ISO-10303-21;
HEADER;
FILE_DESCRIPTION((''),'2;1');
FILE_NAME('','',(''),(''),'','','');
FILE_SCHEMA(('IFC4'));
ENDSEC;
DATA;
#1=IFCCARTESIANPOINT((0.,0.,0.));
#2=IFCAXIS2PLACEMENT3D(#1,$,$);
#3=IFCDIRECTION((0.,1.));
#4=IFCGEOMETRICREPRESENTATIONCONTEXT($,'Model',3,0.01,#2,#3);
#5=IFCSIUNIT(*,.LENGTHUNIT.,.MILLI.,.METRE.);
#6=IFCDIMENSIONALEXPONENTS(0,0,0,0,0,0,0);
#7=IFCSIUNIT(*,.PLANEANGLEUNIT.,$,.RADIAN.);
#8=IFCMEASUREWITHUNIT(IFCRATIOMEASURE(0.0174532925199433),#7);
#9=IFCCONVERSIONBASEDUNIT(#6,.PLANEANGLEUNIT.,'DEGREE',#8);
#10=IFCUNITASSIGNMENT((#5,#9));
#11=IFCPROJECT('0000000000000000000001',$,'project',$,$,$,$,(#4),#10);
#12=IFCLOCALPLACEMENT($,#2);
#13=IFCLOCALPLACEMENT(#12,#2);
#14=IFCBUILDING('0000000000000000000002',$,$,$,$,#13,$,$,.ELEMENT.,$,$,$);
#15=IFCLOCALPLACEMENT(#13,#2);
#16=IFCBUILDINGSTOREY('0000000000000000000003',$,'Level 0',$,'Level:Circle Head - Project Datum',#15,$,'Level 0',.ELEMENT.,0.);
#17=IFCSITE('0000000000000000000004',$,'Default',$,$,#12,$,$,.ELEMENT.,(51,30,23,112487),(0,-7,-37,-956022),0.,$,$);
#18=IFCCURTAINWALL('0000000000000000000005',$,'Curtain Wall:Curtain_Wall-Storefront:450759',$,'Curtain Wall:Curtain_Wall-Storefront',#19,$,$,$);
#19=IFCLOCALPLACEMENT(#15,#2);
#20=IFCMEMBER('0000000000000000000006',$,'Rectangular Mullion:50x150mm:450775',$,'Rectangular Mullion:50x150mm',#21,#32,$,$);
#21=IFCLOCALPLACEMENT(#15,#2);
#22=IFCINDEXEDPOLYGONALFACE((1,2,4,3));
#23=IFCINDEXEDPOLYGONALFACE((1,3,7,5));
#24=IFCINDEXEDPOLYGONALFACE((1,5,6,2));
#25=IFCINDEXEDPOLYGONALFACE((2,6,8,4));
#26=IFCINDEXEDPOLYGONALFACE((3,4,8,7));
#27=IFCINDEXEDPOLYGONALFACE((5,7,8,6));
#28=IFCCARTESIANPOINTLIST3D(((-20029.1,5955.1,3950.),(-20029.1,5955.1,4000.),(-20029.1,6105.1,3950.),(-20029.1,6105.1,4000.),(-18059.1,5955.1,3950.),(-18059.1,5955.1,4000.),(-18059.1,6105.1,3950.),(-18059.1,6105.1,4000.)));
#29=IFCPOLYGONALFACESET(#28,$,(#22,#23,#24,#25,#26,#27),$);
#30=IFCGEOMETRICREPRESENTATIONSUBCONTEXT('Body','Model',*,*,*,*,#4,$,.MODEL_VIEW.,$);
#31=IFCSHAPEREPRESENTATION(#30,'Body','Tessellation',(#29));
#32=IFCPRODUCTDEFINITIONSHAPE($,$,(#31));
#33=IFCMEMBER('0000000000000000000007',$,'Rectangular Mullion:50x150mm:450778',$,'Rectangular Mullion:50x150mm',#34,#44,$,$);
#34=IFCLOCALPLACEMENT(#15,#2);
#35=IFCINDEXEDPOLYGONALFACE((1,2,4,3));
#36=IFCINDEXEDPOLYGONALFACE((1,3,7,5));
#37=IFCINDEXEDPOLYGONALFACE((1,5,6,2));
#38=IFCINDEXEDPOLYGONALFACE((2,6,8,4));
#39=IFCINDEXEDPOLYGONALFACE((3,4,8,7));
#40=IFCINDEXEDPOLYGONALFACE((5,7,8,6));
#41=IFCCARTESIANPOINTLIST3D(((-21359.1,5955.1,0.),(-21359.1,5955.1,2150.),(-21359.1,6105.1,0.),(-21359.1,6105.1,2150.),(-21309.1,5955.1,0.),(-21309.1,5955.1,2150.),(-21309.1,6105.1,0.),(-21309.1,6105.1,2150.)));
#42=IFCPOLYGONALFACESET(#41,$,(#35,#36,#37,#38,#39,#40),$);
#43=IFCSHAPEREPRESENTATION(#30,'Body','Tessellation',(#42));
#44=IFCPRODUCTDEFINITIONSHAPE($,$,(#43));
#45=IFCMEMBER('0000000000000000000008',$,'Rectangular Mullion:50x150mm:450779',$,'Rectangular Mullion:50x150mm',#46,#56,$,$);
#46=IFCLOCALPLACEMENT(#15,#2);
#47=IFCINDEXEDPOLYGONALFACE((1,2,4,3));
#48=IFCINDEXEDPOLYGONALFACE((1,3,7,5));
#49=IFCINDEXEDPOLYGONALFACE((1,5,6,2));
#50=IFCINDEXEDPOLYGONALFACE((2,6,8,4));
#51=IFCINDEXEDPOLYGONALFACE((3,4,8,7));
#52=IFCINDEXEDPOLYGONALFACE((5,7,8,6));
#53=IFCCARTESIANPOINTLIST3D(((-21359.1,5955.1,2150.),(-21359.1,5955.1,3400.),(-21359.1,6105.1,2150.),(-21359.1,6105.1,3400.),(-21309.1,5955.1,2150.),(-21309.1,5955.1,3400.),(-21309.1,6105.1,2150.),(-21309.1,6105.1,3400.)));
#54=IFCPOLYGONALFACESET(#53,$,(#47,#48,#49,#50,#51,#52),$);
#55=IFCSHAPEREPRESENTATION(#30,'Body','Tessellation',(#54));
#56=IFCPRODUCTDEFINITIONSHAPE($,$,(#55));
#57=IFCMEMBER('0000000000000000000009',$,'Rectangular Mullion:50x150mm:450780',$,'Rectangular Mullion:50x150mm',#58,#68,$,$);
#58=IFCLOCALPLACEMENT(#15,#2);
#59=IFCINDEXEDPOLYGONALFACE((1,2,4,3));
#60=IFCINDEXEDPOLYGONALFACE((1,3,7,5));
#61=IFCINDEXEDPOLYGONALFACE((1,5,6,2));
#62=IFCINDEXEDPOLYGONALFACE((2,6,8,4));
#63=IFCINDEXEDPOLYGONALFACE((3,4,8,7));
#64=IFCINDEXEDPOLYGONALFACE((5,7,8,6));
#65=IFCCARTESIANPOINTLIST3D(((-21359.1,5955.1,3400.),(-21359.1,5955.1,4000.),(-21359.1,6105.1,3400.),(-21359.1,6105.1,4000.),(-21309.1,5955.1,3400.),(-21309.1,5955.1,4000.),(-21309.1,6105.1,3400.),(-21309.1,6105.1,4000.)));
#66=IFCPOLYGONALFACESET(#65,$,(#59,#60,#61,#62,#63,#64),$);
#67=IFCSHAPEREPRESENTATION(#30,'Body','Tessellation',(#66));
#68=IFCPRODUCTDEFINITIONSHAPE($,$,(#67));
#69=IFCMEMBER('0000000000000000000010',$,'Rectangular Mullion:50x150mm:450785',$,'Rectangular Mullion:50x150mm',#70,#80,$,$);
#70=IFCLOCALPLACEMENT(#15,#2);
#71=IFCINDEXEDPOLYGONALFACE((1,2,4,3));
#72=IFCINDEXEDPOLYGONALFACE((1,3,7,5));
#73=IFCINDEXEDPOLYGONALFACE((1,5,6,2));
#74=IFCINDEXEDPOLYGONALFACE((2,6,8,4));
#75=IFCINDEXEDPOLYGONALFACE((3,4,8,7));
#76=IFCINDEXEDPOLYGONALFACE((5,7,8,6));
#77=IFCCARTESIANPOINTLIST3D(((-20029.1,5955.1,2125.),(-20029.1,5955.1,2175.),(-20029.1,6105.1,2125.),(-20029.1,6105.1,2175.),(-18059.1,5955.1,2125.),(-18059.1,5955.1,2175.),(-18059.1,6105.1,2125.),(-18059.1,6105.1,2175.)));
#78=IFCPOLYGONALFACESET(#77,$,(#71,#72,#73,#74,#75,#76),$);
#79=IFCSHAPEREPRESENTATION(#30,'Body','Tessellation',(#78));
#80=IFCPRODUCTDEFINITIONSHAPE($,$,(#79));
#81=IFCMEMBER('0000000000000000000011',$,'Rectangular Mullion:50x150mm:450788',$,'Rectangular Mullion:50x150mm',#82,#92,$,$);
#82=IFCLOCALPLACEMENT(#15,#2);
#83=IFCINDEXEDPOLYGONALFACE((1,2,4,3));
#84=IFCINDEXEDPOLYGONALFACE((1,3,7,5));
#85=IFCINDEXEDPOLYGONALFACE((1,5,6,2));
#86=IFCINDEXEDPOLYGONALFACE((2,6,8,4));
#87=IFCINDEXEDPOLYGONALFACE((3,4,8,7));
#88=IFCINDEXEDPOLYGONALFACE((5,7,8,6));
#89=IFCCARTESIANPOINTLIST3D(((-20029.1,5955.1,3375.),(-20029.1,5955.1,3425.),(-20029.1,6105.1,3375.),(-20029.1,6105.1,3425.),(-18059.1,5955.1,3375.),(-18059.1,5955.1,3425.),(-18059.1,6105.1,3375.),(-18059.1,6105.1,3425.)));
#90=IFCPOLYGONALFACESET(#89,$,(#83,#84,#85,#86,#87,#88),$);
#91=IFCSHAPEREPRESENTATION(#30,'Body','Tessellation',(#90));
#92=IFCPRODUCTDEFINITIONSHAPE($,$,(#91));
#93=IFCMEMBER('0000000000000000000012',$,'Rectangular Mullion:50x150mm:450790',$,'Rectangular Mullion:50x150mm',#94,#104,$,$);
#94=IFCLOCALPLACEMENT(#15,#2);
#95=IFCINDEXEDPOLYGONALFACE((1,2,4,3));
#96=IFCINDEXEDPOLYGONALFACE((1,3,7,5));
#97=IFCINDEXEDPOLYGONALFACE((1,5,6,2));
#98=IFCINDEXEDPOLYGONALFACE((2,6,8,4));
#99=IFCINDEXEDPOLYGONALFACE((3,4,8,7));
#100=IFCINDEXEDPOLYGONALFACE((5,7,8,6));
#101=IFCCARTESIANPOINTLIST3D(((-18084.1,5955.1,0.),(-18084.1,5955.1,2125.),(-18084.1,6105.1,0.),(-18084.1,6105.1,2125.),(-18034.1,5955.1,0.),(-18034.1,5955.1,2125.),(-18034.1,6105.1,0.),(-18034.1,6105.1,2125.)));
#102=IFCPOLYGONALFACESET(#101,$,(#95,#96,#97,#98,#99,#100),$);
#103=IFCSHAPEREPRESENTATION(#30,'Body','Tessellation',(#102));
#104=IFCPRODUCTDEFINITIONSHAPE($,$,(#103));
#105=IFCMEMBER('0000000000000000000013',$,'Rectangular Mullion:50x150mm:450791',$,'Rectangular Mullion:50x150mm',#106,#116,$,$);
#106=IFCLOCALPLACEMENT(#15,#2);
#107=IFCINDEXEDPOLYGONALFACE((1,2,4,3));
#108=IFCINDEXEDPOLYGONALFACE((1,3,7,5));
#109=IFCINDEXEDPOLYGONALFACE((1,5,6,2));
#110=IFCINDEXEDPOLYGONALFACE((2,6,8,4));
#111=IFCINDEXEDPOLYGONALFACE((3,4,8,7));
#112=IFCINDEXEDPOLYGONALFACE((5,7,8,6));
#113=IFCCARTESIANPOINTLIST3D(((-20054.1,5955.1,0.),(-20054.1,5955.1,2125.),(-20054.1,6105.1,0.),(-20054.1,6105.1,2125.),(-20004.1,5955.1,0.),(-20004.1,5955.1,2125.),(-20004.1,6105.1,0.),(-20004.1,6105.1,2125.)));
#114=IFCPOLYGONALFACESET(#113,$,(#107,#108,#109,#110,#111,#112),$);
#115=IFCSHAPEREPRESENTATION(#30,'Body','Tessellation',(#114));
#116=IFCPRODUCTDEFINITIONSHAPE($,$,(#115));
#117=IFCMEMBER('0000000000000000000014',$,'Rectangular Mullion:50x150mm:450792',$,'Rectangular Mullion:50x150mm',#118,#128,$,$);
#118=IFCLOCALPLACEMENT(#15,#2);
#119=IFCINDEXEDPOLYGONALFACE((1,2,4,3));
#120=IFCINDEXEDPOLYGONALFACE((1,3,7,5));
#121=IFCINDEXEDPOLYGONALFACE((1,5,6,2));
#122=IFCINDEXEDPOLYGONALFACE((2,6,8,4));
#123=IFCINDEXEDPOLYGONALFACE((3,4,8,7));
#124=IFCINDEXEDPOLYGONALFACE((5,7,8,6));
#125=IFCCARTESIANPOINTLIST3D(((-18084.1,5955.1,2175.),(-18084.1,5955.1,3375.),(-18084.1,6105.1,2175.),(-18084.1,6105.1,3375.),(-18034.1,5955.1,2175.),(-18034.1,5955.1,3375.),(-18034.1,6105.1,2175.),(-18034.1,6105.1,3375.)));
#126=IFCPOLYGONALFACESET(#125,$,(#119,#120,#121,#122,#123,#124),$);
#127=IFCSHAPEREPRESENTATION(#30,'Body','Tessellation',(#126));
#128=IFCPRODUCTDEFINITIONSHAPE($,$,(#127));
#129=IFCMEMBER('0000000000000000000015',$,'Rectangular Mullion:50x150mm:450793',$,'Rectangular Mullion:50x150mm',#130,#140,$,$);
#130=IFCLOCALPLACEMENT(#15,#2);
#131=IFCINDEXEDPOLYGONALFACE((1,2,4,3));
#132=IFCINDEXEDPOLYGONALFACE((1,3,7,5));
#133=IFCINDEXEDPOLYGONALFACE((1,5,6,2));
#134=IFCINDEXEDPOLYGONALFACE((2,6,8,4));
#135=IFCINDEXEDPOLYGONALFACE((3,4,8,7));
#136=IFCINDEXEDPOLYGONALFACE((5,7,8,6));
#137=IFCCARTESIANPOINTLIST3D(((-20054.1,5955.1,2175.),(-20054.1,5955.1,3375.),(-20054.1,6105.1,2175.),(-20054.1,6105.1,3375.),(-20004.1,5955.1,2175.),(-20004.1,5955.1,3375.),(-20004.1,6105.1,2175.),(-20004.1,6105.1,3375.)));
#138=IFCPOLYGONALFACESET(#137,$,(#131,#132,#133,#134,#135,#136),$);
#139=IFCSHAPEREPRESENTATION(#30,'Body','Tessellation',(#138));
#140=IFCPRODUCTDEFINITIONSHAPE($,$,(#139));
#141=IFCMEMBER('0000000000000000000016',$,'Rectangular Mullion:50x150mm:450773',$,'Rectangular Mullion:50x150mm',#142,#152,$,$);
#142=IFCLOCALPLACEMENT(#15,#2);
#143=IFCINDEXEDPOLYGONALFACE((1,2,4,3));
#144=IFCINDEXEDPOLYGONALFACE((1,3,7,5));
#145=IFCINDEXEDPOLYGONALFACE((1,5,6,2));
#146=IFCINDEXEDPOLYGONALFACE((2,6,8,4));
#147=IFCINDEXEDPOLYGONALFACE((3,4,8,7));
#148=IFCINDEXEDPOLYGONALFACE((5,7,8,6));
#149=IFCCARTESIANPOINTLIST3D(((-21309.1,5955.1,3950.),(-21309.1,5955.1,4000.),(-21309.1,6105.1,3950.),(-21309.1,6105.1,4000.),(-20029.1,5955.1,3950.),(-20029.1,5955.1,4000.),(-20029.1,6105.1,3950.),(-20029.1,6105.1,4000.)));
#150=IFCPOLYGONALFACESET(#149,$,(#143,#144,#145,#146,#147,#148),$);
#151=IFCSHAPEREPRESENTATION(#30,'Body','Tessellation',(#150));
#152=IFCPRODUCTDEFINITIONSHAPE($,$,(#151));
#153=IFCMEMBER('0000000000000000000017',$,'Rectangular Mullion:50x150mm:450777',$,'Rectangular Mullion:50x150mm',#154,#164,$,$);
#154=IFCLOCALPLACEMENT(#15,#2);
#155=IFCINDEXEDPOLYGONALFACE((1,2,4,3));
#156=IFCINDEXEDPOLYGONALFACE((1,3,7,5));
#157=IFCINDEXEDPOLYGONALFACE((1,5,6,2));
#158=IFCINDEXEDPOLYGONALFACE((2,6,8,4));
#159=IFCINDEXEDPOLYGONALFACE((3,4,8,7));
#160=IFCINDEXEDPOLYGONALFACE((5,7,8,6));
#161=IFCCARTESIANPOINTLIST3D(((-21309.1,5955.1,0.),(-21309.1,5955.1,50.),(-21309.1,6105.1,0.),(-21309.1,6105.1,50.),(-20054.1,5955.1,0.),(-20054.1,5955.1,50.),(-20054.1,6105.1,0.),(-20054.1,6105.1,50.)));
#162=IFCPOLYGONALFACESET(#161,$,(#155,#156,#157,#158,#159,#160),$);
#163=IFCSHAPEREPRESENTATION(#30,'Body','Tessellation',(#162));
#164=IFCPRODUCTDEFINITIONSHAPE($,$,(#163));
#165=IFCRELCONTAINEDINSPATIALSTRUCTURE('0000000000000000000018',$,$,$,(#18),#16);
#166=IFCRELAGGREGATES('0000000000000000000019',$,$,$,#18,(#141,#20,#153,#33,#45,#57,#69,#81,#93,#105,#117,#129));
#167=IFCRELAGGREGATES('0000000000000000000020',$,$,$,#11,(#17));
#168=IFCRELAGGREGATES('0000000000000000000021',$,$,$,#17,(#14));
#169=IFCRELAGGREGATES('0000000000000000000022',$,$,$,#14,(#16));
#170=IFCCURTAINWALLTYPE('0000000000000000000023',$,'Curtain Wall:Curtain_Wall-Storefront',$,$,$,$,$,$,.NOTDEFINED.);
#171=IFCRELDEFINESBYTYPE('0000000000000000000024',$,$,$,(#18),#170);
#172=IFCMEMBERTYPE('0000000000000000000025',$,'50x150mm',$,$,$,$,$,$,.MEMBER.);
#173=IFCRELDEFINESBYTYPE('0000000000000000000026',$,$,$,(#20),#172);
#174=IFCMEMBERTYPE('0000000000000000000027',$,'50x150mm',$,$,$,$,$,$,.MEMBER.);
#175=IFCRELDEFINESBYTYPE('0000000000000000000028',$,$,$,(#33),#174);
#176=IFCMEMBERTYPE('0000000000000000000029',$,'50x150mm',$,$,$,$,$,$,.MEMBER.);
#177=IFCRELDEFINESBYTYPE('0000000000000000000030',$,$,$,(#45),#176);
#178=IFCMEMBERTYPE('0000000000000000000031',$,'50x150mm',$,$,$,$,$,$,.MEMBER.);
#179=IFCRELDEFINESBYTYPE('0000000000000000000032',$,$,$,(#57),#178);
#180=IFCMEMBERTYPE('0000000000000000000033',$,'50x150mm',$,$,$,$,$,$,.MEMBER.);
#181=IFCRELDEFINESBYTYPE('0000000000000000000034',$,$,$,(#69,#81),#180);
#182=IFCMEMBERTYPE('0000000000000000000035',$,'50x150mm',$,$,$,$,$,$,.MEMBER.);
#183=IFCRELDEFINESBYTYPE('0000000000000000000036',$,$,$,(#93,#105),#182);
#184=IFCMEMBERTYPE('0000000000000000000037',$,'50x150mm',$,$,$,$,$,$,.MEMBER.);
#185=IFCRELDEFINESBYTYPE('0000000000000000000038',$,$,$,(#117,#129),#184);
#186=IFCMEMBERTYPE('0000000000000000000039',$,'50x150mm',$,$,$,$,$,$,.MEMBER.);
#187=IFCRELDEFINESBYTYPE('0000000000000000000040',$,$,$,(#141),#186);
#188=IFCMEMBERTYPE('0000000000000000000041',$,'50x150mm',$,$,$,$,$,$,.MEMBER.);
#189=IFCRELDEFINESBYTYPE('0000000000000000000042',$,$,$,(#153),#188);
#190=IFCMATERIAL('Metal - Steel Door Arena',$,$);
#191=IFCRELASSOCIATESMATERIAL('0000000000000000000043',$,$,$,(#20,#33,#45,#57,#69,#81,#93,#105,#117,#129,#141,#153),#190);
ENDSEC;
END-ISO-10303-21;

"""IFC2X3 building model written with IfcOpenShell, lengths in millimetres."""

from ifc_helpers import new_model, entity, si_unit, converted_unit, direction, frame, origin, origin_2d_with_axis, place, context, subcontext, project, spatial, rectangle, extrude, source, transform, mapped, material, type_object, type_shapes, element, aggregate, save


model = new_model("IFC2X3")

# Units and contexts
model_context = context("Model", 3, precision=0.01, world=origin(), true_north=direction((0.0, 1.0)))
body_context = subcontext(model_context, "Body", "Model", "MODEL_VIEW")
ifc_project = project(units=[si_unit("LENGTHUNIT", "METRE", prefix="MILLI"), converted_unit("PLANEANGLEUNIT", "DEGREE", entity("IfcRatioMeasure", 0.0174532925199433), si_unit("PLANEANGLEUNIT", "RADIAN"), dimensions=[0, 0, 0, 0, 0, 0, 0])], contexts=[model_context])

# Site, building, storey
site_placement = place(None, origin())
site = spatial("IfcSite", under=ifc_project, at=site_placement, Name="Default", CompositionType="ELEMENT", RefLatitude=(51, 30, 23, 112487), RefLongitude=(0, -7, -37, -956022), RefElevation=0.0)
building_placement = place(site_placement, origin())
building = spatial("IfcBuilding", under=site, at=building_placement, CompositionType="ELEMENT")
storey_placement = place(building_placement, origin())
storey = spatial("IfcBuildingStorey", under=building, at=storey_placement, Name="Level 0", ObjectType="Level:Circle Head - Project Datum", LongName="Level 0", CompositionType="ELEMENT", Elevation=0.0)

# Curtain wall, members
curtain_wall_type = type_object("IfcCurtainWallType", Name="Curtain Wall:Curtain_Wall-Storefront", PredefinedType="NOTDEFINED")
curtain_wall_placement = place(storey_placement, origin())
curtain_wall = element("IfcCurtainWall", 1, at=curtain_wall_placement, inside=storey, type_object=curtain_wall_type, Name="Curtain Wall:Curtain_Wall-Storefront:450759", ObjectType="Curtain Wall:Curtain_Wall-Storefront")
ifc_material_1 = material(Name="Metal - Steel Door Arena")
member_type_1 = type_object("IfcMemberType", Name="50x150mm", PredefinedType="MEMBER")
shared_shape_1 = source(origin(), body_context, "Body", "SweptSolid", [
    extrude(rectangle(XDim=150.0, YDim=50.0, at=origin_2d_with_axis()), frame((-25.0, 0.0, -1970.0), z_axis=(0.0, 0.0, 1.0), x_axis=(0.0, -1.0, 0.0)), (0.0, 0.0, 1.0), 1970.0),
])
type_shapes(member_type_1, [shared_shape_1])
member_1_placement = place(storey_placement, frame((-20029.1, 6030.1, 4000.0), z_axis=(-1.0, 0.0, 0.0), x_axis=(0.0, 0.0, 1.0)))
member_1 = element("IfcMember", 2, at=member_1_placement, type_object=member_type_1, material=ifc_material_1, Name="Rectangular Mullion:50x150mm:450775", ObjectType="Rectangular Mullion:50x150mm", context=body_context, shape_type="MappedRepresentation", body=[
    mapped(shared_shape_1, transform((0.0, 0.0, 0.0), scale=1.0)),
])
member_type_2 = type_object("IfcMemberType", Name="50x150mm", PredefinedType="MEMBER")
shared_shape_2 = source(origin(), body_context, "Body", "SweptSolid", [
    extrude(rectangle(XDim=150.0, YDim=50.0, at=origin_2d_with_axis()), frame((-25.0, 0.0, -2150.0), z_axis=(0.0, 0.0, 1.0), x_axis=(0.0, -1.0, 0.0)), (0.0, 0.0, 1.0), 2150.0),
])
type_shapes(member_type_2, [shared_shape_2])
member_2_placement = place(storey_placement, frame((-21359.1, 6030.1, 0.0), z_axis=(0.0, 0.0, -1.0), x_axis=(-1.0, 0.0, 0.0)))
member_2 = element("IfcMember", 3, at=member_2_placement, type_object=member_type_2, material=ifc_material_1, Name="Rectangular Mullion:50x150mm:450778", ObjectType="Rectangular Mullion:50x150mm", context=body_context, shape_type="MappedRepresentation", body=[
    mapped(shared_shape_2, transform((0.0, 0.0, 0.0), scale=1.0)),
])
member_type_3 = type_object("IfcMemberType", Name="50x150mm", PredefinedType="MEMBER")
shared_shape_3 = source(origin(), body_context, "Body", "SweptSolid", [
    extrude(rectangle(XDim=150.0, YDim=50.0, at=origin_2d_with_axis()), frame((-25.0, 0.0, -1250.0), z_axis=(0.0, 0.0, 1.0), x_axis=(0.0, -1.0, 0.0)), (0.0, 0.0, 1.0), 1250.0),
])
type_shapes(member_type_3, [shared_shape_3])
member_3_placement = place(storey_placement, frame((-21359.1, 6030.1, 2150.0), z_axis=(0.0, 0.0, -1.0), x_axis=(-1.0, 0.0, 0.0)))
member_3 = element("IfcMember", 4, at=member_3_placement, type_object=member_type_3, material=ifc_material_1, Name="Rectangular Mullion:50x150mm:450779", ObjectType="Rectangular Mullion:50x150mm", context=body_context, shape_type="MappedRepresentation", body=[
    mapped(shared_shape_3, transform((0.0, 0.0, 0.0), scale=1.0)),
])
member_type_4 = type_object("IfcMemberType", Name="50x150mm", PredefinedType="MEMBER")
shared_shape_4 = source(origin(), body_context, "Body", "SweptSolid", [
    extrude(rectangle(XDim=150.0, YDim=50.0, at=origin_2d_with_axis()), frame((-25.0, 0.0, -600.0), z_axis=(0.0, 0.0, 1.0), x_axis=(0.0, -1.0, 0.0)), (0.0, 0.0, 1.0), 600.0),
])
type_shapes(member_type_4, [shared_shape_4])
member_4_placement = place(storey_placement, frame((-21359.1, 6030.1, 3400.0), z_axis=(0.0, 0.0, -1.0), x_axis=(-1.0, 0.0, 0.0)))
member_4 = element("IfcMember", 5, at=member_4_placement, type_object=member_type_4, material=ifc_material_1, Name="Rectangular Mullion:50x150mm:450780", ObjectType="Rectangular Mullion:50x150mm", context=body_context, shape_type="MappedRepresentation", body=[
    mapped(shared_shape_4, transform((0.0, 0.0, 0.0), scale=1.0)),
])
member_type_5 = type_object("IfcMemberType", Name="50x150mm", PredefinedType="MEMBER")
shared_shape_5 = source(origin(), body_context, "Body", "SweptSolid", [
    extrude(rectangle(XDim=150.0, YDim=50.0, at=origin_2d_with_axis()), frame((0.0, 0.0, -1970.0), z_axis=(0.0, 0.0, 1.0), x_axis=(0.0, -1.0, 0.0)), (0.0, 0.0, 1.0), 1970.0),
])
type_shapes(member_type_5, [shared_shape_5])
member_5_placement = place(storey_placement, frame((-20029.1, 6030.1, 2150.0), z_axis=(-1.0, 0.0, 0.0), x_axis=(0.0, 0.0, 1.0)))
member_5 = element("IfcMember", 6, at=member_5_placement, type_object=member_type_5, material=ifc_material_1, Name="Rectangular Mullion:50x150mm:450785", ObjectType="Rectangular Mullion:50x150mm", context=body_context, shape_type="MappedRepresentation", body=[
    mapped(shared_shape_5, transform((0.0, 0.0, 0.0), scale=1.0)),
])
member_6_placement = place(storey_placement, frame((-20029.1, 6030.1, 3400.0), z_axis=(-1.0, 0.0, 0.0), x_axis=(0.0, 0.0, 1.0)))
member_6 = element("IfcMember", 7, at=member_6_placement, type_object=member_type_5, material=ifc_material_1, Name="Rectangular Mullion:50x150mm:450788", ObjectType="Rectangular Mullion:50x150mm", context=body_context, shape_type="MappedRepresentation", body=[
    mapped(shared_shape_5, transform((0.0, 0.0, 0.0), scale=1.0)),
])
member_type_6 = type_object("IfcMemberType", Name="50x150mm", PredefinedType="MEMBER")
shared_shape_6 = source(origin(), body_context, "Body", "SweptSolid", [
    extrude(rectangle(XDim=150.0, YDim=50.0, at=origin_2d_with_axis()), frame((0.0, 0.0, -2125.0), z_axis=(0.0, 0.0, 1.0), x_axis=(0.0, -1.0, 0.0)), (0.0, 0.0, 1.0), 2125.0),
])
type_shapes(member_type_6, [shared_shape_6])
member_7_placement = place(storey_placement, frame((-18059.1, 6030.1, 0.0), z_axis=(0.0, 0.0, -1.0), x_axis=(-1.0, 0.0, 0.0)))
member_7 = element("IfcMember", 8, at=member_7_placement, type_object=member_type_6, material=ifc_material_1, Name="Rectangular Mullion:50x150mm:450790", ObjectType="Rectangular Mullion:50x150mm", context=body_context, shape_type="MappedRepresentation", body=[
    mapped(shared_shape_6, transform((0.0, 0.0, 0.0), scale=1.0)),
])
member_8_placement = place(storey_placement, frame((-20029.1, 6030.1, 0.0), z_axis=(0.0, 0.0, -1.0), x_axis=(-1.0, 0.0, 0.0)))
member_8 = element("IfcMember", 9, at=member_8_placement, type_object=member_type_6, material=ifc_material_1, Name="Rectangular Mullion:50x150mm:450791", ObjectType="Rectangular Mullion:50x150mm", context=body_context, shape_type="MappedRepresentation", body=[
    mapped(shared_shape_6, transform((0.0, 0.0, 0.0), scale=1.0)),
])
member_type_7 = type_object("IfcMemberType", Name="50x150mm", PredefinedType="MEMBER")
shared_shape_7 = source(origin(), body_context, "Body", "SweptSolid", [
    extrude(rectangle(XDim=150.0, YDim=50.0, at=origin_2d_with_axis()), frame((0.0, 0.0, -1200.0), z_axis=(0.0, 0.0, 1.0), x_axis=(0.0, -1.0, 0.0)), (0.0, 0.0, 1.0), 1200.0),
])
type_shapes(member_type_7, [shared_shape_7])
member_9_placement = place(storey_placement, frame((-18059.1, 6030.1, 2175.0), z_axis=(0.0, 0.0, -1.0), x_axis=(-1.0, 0.0, 0.0)))
member_9 = element("IfcMember", 10, at=member_9_placement, type_object=member_type_7, material=ifc_material_1, Name="Rectangular Mullion:50x150mm:450792", ObjectType="Rectangular Mullion:50x150mm", context=body_context, shape_type="MappedRepresentation", body=[
    mapped(shared_shape_7, transform((0.0, 0.0, 0.0), scale=1.0)),
])
member_10_placement = place(storey_placement, frame((-20029.1, 6030.1, 2175.0), z_axis=(0.0, 0.0, -1.0), x_axis=(-1.0, 0.0, 0.0)))
member_10 = element("IfcMember", 11, at=member_10_placement, type_object=member_type_7, material=ifc_material_1, Name="Rectangular Mullion:50x150mm:450793", ObjectType="Rectangular Mullion:50x150mm", context=body_context, shape_type="MappedRepresentation", body=[
    mapped(shared_shape_7, transform((0.0, 0.0, 0.0), scale=1.0)),
])
member_type_8 = type_object("IfcMemberType", Name="50x150mm", PredefinedType="MEMBER")
shared_shape_8 = source(origin(), body_context, "Body", "SweptSolid", [
    extrude(rectangle(XDim=150.0, YDim=50.0, at=origin_2d_with_axis()), frame((-25.0, 0.0, -1280.0), z_axis=(0.0, 0.0, 1.0), x_axis=(0.0, -1.0, 0.0)), (0.0, 0.0, 1.0), 1280.0),
])
type_shapes(member_type_8, [shared_shape_8])
member_11_placement = place(storey_placement, frame((-21309.1, 6030.1, 4000.0), z_axis=(-1.0, 0.0, 0.0), x_axis=(0.0, 0.0, 1.0)))
member_11 = element("IfcMember", 12, at=member_11_placement, type_object=member_type_8, material=ifc_material_1, Name="Rectangular Mullion:50x150mm:450773", ObjectType="Rectangular Mullion:50x150mm", context=body_context, shape_type="MappedRepresentation", body=[
    mapped(shared_shape_8, transform((0.0, 0.0, 0.0), scale=1.0)),
])
member_type_9 = type_object("IfcMemberType", Name="50x150mm", PredefinedType="MEMBER")
shared_shape_9 = source(origin(), body_context, "Body", "SweptSolid", [
    extrude(rectangle(XDim=150.0, YDim=50.0, at=origin_2d_with_axis()), frame((-25.0, 0.0, -1255.0), z_axis=(0.0, 0.0, 1.0), x_axis=(0.0, -1.0, 0.0)), (0.0, 0.0, 1.0), 1255.0),
])
type_shapes(member_type_9, [shared_shape_9])
member_12_placement = place(storey_placement, frame((-20054.1, 6030.1, 0.0), z_axis=(1.0, 0.0, 0.0), x_axis=(0.0, 0.0, -1.0)))
member_12 = element("IfcMember", 13, at=member_12_placement, type_object=member_type_9, material=ifc_material_1, Name="Rectangular Mullion:50x150mm:450777", ObjectType="Rectangular Mullion:50x150mm", context=body_context, shape_type="MappedRepresentation", body=[
    mapped(shared_shape_9, transform((0.0, 0.0, 0.0), scale=1.0)),
])
aggregate(curtain_wall, [member_11, member_1, member_12, member_2, member_3, member_4, member_5, member_6, member_7, member_8, member_9, member_10])

save(model, "model.ifc")
